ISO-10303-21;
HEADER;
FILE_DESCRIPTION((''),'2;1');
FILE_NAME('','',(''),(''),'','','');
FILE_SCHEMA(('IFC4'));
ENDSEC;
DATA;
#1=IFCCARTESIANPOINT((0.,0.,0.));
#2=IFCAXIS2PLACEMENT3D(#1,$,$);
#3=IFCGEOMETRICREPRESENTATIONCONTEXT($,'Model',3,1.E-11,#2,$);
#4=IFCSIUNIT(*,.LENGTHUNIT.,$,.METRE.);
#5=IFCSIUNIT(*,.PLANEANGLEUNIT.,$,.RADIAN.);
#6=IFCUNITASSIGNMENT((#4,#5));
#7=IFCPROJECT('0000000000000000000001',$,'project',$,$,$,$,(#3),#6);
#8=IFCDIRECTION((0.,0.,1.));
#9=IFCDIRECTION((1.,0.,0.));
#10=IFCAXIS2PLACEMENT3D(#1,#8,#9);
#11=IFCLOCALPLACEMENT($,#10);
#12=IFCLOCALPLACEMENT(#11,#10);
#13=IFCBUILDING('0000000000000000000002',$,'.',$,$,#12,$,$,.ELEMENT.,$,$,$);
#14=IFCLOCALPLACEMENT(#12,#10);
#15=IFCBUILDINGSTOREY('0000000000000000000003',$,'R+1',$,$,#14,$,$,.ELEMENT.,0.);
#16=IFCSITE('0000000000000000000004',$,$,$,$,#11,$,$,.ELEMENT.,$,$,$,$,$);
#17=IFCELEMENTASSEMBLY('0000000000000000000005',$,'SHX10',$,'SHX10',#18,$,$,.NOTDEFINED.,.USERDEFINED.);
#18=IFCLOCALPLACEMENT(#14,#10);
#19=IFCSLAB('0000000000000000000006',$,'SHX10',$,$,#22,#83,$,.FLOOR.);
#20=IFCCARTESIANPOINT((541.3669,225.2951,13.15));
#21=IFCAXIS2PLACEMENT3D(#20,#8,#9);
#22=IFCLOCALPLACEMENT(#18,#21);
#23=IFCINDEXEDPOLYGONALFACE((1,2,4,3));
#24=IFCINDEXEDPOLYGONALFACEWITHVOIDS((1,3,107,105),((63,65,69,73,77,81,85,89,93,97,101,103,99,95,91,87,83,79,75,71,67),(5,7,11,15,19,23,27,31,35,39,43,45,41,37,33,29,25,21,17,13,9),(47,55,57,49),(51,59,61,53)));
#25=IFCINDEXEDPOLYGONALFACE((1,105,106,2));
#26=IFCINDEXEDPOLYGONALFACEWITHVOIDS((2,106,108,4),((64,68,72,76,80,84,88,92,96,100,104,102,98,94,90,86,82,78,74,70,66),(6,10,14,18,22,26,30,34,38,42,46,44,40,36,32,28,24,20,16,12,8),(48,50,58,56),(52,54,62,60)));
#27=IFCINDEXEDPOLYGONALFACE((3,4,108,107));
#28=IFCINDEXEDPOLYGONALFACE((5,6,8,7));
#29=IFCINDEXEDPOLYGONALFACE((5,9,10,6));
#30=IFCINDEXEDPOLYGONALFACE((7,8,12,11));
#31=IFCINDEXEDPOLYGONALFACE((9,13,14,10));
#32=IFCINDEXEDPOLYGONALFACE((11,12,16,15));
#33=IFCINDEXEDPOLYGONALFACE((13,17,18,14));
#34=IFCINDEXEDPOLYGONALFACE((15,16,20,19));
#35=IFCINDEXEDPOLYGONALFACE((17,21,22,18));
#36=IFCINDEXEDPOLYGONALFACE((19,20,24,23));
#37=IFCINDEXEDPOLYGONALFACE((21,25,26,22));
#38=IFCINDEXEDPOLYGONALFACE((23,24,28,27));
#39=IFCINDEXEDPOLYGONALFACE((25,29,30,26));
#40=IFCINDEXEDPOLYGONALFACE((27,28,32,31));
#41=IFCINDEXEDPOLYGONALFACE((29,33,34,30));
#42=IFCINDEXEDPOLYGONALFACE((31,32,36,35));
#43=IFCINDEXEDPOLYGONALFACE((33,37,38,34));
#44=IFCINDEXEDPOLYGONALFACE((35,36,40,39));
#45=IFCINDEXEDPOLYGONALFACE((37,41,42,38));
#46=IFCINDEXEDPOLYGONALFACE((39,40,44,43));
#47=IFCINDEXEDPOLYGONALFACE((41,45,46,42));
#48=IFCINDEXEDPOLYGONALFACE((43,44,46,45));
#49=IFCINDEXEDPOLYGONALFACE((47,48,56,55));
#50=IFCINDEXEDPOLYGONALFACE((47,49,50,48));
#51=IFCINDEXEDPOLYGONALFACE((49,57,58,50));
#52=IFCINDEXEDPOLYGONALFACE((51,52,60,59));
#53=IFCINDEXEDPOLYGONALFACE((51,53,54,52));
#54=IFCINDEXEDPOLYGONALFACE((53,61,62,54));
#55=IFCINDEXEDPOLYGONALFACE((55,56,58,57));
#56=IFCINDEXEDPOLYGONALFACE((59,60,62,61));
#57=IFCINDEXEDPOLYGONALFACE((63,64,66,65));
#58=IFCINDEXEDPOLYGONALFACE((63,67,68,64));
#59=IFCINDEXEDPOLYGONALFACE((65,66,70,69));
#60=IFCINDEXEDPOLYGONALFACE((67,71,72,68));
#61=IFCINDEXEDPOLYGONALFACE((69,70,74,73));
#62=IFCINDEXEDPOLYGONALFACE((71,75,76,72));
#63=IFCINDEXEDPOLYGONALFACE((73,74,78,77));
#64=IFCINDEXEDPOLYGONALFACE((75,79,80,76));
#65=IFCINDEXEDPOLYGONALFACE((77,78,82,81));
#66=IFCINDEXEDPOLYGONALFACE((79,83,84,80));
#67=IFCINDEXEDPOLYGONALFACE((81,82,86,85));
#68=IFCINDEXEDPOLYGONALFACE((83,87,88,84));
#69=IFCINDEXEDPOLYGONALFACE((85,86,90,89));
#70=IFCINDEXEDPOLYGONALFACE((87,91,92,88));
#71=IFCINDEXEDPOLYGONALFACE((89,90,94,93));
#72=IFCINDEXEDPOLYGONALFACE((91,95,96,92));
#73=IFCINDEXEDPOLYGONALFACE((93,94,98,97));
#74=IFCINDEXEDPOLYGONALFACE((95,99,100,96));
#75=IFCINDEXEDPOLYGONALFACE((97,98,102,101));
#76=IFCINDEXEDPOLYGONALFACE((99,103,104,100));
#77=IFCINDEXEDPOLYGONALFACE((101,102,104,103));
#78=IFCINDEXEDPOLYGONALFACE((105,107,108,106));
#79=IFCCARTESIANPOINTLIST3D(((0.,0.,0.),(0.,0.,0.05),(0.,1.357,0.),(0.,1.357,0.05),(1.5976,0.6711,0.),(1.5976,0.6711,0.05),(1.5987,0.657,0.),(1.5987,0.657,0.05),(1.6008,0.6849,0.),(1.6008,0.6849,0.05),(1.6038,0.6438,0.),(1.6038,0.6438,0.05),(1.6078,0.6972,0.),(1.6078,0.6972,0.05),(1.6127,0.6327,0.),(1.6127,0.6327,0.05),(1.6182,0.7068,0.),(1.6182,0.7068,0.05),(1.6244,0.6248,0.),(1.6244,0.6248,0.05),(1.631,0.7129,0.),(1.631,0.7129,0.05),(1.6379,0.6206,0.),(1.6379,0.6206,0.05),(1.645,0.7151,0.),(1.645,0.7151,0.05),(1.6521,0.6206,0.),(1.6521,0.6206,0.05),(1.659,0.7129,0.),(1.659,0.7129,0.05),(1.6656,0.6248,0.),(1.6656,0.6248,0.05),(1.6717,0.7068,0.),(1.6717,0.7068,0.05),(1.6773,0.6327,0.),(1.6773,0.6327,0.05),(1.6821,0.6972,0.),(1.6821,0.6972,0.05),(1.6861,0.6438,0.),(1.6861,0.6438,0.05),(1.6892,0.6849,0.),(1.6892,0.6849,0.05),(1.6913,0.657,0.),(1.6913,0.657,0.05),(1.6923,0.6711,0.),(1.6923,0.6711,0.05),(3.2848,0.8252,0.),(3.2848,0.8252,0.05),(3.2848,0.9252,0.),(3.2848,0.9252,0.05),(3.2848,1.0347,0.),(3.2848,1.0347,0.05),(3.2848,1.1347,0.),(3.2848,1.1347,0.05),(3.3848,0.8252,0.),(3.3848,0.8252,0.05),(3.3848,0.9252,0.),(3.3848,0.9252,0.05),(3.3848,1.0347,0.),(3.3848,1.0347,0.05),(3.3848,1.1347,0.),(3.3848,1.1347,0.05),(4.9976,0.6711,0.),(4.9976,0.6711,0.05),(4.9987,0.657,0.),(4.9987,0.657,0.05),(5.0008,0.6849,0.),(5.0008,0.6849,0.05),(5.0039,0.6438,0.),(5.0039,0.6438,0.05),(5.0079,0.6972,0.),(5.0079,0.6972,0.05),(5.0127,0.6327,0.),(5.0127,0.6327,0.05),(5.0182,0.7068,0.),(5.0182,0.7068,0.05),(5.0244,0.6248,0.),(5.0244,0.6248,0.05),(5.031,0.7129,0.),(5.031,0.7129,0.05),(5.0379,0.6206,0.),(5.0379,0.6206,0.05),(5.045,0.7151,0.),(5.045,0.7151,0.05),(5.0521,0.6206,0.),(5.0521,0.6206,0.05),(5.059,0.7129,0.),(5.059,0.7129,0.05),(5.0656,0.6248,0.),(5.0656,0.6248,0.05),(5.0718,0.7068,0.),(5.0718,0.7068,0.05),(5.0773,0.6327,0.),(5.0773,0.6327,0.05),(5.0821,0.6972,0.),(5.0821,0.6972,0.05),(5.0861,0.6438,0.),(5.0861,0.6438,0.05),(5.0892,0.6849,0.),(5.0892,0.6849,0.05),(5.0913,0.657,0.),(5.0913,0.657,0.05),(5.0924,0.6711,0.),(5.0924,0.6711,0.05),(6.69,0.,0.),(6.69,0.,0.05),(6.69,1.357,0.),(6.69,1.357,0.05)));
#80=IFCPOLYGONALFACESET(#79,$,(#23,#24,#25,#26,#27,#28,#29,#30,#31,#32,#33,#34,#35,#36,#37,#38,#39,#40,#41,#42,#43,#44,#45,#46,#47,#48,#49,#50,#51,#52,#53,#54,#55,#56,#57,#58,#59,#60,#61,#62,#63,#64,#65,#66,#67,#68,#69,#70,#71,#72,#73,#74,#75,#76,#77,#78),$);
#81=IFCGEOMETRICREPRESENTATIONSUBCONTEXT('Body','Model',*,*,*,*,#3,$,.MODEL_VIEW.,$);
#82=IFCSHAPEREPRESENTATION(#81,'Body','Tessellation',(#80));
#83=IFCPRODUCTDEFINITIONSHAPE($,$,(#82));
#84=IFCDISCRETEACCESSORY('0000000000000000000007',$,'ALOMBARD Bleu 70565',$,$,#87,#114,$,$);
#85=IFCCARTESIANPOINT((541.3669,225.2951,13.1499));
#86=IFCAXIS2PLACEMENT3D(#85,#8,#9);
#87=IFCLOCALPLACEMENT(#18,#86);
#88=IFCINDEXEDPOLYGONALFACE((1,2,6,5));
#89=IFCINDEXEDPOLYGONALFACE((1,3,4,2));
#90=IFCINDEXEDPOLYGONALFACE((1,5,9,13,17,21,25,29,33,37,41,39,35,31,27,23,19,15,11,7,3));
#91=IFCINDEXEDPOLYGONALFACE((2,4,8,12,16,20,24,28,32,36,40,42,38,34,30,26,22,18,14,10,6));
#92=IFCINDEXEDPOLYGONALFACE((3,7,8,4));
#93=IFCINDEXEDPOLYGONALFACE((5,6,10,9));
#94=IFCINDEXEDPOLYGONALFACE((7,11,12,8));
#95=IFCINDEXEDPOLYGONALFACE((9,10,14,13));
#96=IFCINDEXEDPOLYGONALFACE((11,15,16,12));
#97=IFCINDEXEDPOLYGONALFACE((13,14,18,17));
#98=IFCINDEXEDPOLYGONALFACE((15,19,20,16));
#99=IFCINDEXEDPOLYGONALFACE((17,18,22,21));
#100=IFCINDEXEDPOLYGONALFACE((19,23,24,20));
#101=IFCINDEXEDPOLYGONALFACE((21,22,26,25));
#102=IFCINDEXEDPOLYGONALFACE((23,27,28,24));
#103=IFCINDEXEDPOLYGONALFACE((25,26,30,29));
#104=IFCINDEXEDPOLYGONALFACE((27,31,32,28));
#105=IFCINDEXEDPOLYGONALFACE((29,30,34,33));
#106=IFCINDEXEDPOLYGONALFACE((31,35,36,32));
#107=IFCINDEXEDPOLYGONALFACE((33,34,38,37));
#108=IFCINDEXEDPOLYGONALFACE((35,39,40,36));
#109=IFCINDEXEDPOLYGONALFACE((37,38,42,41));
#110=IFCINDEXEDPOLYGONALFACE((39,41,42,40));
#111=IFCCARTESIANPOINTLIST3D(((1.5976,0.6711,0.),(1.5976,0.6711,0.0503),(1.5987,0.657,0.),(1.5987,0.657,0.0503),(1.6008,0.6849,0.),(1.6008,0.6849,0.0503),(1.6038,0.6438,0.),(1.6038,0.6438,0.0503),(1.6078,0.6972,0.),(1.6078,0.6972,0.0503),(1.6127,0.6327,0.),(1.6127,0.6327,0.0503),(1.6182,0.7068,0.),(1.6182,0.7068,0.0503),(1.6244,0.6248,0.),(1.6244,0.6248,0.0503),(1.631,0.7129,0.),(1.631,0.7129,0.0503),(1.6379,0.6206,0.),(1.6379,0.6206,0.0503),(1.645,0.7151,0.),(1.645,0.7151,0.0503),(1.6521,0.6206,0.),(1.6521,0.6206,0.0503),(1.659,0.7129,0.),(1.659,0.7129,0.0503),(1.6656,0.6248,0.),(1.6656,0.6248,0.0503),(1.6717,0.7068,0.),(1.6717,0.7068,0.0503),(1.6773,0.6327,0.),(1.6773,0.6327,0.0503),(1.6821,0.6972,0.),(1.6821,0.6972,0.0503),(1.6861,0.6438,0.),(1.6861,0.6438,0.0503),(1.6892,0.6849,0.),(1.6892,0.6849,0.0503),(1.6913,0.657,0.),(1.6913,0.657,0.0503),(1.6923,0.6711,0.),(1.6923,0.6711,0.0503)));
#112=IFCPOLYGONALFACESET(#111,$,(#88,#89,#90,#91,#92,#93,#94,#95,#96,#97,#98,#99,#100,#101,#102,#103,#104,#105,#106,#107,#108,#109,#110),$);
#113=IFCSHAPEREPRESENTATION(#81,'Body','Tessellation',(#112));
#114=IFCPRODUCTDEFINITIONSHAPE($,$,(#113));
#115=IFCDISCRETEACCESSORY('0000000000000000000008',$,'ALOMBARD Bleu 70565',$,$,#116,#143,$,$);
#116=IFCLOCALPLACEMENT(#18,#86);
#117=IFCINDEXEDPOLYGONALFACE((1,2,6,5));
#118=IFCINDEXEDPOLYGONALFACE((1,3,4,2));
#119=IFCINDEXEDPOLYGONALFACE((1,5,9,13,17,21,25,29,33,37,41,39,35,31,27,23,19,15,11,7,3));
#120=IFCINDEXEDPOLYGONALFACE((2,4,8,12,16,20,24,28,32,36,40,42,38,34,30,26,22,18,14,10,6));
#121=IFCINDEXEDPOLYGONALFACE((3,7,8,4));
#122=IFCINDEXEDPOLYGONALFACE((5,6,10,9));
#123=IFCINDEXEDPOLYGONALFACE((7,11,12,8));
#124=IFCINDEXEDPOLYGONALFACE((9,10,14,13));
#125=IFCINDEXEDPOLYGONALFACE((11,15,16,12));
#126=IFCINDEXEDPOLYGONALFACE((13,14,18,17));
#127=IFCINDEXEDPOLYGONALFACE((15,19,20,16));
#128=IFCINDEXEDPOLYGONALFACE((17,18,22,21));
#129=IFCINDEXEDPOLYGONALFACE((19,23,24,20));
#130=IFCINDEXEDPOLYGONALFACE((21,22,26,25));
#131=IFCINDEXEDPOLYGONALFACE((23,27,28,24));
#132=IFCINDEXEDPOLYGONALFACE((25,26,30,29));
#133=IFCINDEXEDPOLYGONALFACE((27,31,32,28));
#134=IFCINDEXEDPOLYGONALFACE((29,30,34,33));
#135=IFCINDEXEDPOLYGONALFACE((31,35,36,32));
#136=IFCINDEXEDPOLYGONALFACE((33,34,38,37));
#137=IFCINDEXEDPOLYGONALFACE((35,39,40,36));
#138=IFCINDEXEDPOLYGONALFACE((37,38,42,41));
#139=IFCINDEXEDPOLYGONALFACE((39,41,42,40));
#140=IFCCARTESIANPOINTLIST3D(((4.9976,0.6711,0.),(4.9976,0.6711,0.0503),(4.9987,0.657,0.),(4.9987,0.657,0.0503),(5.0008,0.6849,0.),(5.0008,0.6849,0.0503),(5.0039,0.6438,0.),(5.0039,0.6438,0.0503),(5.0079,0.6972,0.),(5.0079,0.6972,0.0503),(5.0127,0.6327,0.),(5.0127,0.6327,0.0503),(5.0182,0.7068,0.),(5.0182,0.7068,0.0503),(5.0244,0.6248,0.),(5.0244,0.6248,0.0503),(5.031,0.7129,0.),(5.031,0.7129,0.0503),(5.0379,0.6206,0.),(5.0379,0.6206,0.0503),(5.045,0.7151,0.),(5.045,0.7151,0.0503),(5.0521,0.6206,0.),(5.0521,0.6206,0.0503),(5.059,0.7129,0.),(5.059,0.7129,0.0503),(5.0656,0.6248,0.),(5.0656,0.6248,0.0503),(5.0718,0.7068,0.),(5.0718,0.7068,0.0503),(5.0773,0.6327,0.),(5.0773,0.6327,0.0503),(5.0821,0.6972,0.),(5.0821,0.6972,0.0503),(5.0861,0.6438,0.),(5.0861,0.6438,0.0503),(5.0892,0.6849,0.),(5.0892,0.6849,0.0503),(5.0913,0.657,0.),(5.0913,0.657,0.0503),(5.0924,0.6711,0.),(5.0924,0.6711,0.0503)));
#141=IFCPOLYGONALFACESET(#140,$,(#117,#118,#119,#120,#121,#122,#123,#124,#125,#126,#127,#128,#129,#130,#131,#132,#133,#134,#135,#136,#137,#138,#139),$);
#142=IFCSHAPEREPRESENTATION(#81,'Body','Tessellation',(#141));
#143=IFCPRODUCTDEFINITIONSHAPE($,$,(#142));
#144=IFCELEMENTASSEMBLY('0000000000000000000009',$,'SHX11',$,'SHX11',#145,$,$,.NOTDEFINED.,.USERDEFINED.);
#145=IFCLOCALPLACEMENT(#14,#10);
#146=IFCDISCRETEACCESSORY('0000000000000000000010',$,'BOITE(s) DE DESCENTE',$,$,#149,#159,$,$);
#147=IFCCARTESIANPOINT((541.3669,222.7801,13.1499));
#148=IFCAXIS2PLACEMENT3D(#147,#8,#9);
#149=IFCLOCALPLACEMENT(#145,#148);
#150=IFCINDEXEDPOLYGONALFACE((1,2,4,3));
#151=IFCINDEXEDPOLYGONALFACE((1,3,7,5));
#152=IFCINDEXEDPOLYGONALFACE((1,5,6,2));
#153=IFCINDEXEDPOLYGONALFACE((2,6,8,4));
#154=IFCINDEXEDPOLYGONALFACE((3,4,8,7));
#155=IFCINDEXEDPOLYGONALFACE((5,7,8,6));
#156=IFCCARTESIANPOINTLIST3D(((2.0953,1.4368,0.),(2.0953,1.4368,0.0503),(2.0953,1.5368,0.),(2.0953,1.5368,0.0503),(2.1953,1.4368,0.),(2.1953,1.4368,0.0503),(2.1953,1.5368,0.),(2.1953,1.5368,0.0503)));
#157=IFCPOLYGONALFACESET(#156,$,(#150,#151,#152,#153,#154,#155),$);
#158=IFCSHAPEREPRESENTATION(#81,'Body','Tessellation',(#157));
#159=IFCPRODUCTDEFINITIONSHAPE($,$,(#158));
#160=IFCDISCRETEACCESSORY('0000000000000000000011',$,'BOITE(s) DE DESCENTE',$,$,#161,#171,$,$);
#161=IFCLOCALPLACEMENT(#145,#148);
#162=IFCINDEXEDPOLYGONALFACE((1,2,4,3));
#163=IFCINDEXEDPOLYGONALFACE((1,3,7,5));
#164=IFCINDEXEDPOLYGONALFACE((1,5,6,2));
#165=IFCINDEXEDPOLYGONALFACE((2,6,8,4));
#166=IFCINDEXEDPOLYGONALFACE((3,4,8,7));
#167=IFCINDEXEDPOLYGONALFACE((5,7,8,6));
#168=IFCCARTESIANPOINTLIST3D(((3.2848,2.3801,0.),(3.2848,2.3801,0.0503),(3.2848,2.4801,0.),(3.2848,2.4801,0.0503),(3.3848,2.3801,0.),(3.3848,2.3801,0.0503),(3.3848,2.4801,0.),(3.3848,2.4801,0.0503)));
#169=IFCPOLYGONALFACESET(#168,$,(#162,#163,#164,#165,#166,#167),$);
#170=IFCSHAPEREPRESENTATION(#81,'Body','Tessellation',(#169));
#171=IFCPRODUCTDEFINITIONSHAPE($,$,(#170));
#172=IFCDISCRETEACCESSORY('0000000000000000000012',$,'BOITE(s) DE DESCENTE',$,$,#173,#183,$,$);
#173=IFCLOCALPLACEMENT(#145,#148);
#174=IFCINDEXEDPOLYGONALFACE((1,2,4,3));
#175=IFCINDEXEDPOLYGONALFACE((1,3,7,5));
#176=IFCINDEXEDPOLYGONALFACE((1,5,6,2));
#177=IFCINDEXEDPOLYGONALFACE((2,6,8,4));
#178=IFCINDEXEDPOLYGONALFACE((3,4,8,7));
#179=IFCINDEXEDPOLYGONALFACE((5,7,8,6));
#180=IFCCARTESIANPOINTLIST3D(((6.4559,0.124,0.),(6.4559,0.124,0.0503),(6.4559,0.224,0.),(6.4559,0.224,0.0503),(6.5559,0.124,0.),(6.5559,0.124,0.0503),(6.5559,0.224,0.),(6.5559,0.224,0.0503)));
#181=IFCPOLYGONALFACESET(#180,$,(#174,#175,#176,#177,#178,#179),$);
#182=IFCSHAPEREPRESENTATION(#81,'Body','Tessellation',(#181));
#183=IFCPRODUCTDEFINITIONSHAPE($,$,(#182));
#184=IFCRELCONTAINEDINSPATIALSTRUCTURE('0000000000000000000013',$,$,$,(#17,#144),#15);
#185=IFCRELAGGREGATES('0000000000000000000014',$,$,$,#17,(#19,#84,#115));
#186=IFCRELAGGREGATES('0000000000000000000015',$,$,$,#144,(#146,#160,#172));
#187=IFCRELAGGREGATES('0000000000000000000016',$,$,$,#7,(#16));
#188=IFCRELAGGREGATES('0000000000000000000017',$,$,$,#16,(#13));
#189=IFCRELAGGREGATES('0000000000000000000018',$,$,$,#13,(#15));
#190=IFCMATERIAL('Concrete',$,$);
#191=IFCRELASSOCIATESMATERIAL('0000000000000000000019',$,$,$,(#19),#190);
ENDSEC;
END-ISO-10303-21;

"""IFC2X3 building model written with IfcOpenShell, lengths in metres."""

from ifc_helpers import new_model, si_unit, frame, frame_2d, origin, origin_with_axes, origin_2d_with_axis, place, context, subcontext, project, spatial, polyline, circle, outline, extrude, material, element, aggregate, save


model = new_model("IFC2X3")

# Units and contexts
model_context = context("Model", 3, precision=1e-11, world=origin())
body_context = subcontext(model_context, "Body", "Model", "MODEL_VIEW")
ifc_project = project(units=[si_unit("LENGTHUNIT", "METRE"), si_unit("PLANEANGLEUNIT", "RADIAN")], contexts=[model_context])

# Site, building, storey
site_placement = place(None, origin_with_axes())
site = spatial("IfcSite", under=ifc_project, at=site_placement, CompositionType="ELEMENT")
building_placement = place(site_placement, origin_with_axes())
building = spatial("IfcBuilding", under=site, at=building_placement, Name=".", CompositionType="ELEMENT")
storey_placement = place(building_placement, origin_with_axes())
storey = spatial("IfcBuildingStorey", under=building, at=storey_placement, Name="R+1", CompositionType="ELEMENT", Elevation=0.0)

# Element assembly, slab, openings, discrete accessories
assembly_1_placement = place(storey_placement, origin_with_axes())
assembly_1 = element("IfcElementAssembly", 1, at=assembly_1_placement, inside=storey, Name="SHX10", ObjectType="SHX10", AssemblyPlace="NOTDEFINED", PredefinedType="USERDEFINED")
ifc_material = material(Name="Concrete")
slab_placement = place(assembly_1_placement, frame((541.3669, 225.2951, 13.15), z_axis=(0.0, 0.0, 1.0), x_axis=(1.0, 0.0, 0.0)))
slab = element("IfcSlab", 2, at=slab_placement, material=ifc_material, Name="SHX10", PredefinedType="FLOOR", context=body_context, shape_type="SweptSolid", body=[
    extrude(outline(polyline([(0.0, 0.0), (0.0, -6.69), (1.3571, -6.69), (1.3571, 0.0), (0.0, 0.0)])), frame((0.0, 0.0, 0.0), z_axis=(0.0, 0.0, 1.0), x_axis=(0.0, 1.0, 0.0)), (0.0, 0.0, 1.0), 0.05),
])
opening_1_placement = place(slab_placement, frame((1.645, 0.6676, 0.0), z_axis=(0.0, 0.0, 1.0), x_axis=(1.0, 0.0, 0.0)))
element("IfcOpeningElement", 3, at=opening_1_placement, cuts=slab, ObjectType="Opening", context=body_context, shape_type="SweptSolid", body=[
    extrude(circle(Radius=0.0475, at=origin_2d_with_axis()), frame((0.0, 0.0, 0.0), z_axis=(0.0, 0.0, 1.0), x_axis=(0.0, 1.0, 0.0)), (0.0, 0.0, 1.0), 0.05),
])
opening_2_placement = place(slab_placement, frame((5.045, 0.6676, 0.0), z_axis=(0.0, 0.0, 1.0), x_axis=(1.0, 0.0, 0.0)))
element("IfcOpeningElement", 4, at=opening_2_placement, cuts=slab, ObjectType="Opening", context=body_context, shape_type="SweptSolid", body=[
    extrude(circle(Radius=0.0475, at=origin_2d_with_axis()), frame((0.0, 0.0, 0.0), z_axis=(0.0, 0.0, 1.0), x_axis=(0.0, 1.0, 0.0)), (0.0, 0.0, 1.0), 0.05),
])
opening_3_placement = place(slab_placement, origin_with_axes())
element("IfcOpeningElement", 5, at=opening_3_placement, cuts=slab, ObjectType="Opening", context=body_context, shape_type="SweptSolid", body=[
    extrude(outline(polyline([(0.8252, -3.2848), (0.8252, -3.3848), (0.9252, -3.3848), (0.9252, -3.2848), (0.8252, -3.2848)])), frame((0.0, 0.0, 0.0), z_axis=(0.0, 0.0, 1.0), x_axis=(0.0, 1.0, 0.0)), (0.0, 0.0, 1.0), 0.05),
])
opening_4_placement = place(slab_placement, origin_with_axes())
element("IfcOpeningElement", 6, at=opening_4_placement, cuts=slab, ObjectType="Opening", context=body_context, shape_type="SweptSolid", body=[
    extrude(outline(polyline([(1.0347, -3.2848), (1.0347, -3.3848), (1.1347, -3.3848), (1.1347, -3.2848), (1.0347, -3.2848)])), frame((0.0, 0.0, 0.0), z_axis=(0.0, 0.0, 1.0), x_axis=(0.0, 1.0, 0.0)), (0.0, 0.0, 1.0), 0.05),
])
discrete_accessory_1_placement = place(assembly_1_placement, frame((541.3669, 225.2951, 13.1499), z_axis=(0.0, 0.0, 1.0), x_axis=(1.0, 0.0, 0.0)))
discrete_accessory_1 = element("IfcDiscreteAccessory", 7, at=discrete_accessory_1_placement, Name="ALOMBARD Bleu 70565", context=body_context, shape_type="SweptSolid", body=[
    extrude(circle(Radius=0.0475, at=frame_2d((0.6676, -1.645), x_axis=(1.0, 0.0))), frame((0.0, 0.0, 0.0), z_axis=(0.0, 0.0, 1.0), x_axis=(0.0, 1.0, 0.0)), (0.0, 0.0, 1.0), 0.0503),
])
discrete_accessory_2_placement = place(assembly_1_placement, frame((541.3669, 225.2951, 13.1499), z_axis=(0.0, 0.0, 1.0), x_axis=(1.0, 0.0, 0.0)))
discrete_accessory_2 = element("IfcDiscreteAccessory", 8, at=discrete_accessory_2_placement, Name="ALOMBARD Bleu 70565", context=body_context, shape_type="SweptSolid", body=[
    extrude(circle(Radius=0.0475, at=frame_2d((0.6676, -5.045), x_axis=(1.0, 0.0))), frame((0.0, 0.0, 0.0), z_axis=(0.0, 0.0, 1.0), x_axis=(0.0, 1.0, 0.0)), (0.0, 0.0, 1.0), 0.0503),
])
aggregate(assembly_1, [slab, discrete_accessory_1, discrete_accessory_2])

# Element assembly, discrete accessories
assembly_2_placement = place(storey_placement, origin_with_axes())
assembly_2 = element("IfcElementAssembly", 9, at=assembly_2_placement, inside=storey, Name="SHX11", ObjectType="SHX11", AssemblyPlace="NOTDEFINED", PredefinedType="USERDEFINED")
discrete_accessory_3_placement = place(assembly_2_placement, frame((541.3669, 222.7801, 13.1499), z_axis=(0.0, 0.0, 1.0), x_axis=(1.0, 0.0, 0.0)))
discrete_accessory_3 = element("IfcDiscreteAccessory", 10, at=discrete_accessory_3_placement, Name="BOITE(s) DE DESCENTE", context=body_context, shape_type="SweptSolid", body=[
    extrude(outline(polyline([(1.4368, -2.0953), (1.4368, -2.1953), (1.5368, -2.1953), (1.5368, -2.0953), (1.4368, -2.0953)])), frame((0.0, 0.0, 0.0), z_axis=(0.0, 0.0, 1.0), x_axis=(0.0, 1.0, 0.0)), (0.0, 0.0, 1.0), 0.0503),
])
discrete_accessory_4_placement = place(assembly_2_placement, frame((541.3669, 222.7801, 13.1499), z_axis=(0.0, 0.0, 1.0), x_axis=(1.0, 0.0, 0.0)))
discrete_accessory_4 = element("IfcDiscreteAccessory", 11, at=discrete_accessory_4_placement, Name="BOITE(s) DE DESCENTE", context=body_context, shape_type="SweptSolid", body=[
    extrude(outline(polyline([(2.3801, -3.2848), (2.3801, -3.3848), (2.4801, -3.3848), (2.4801, -3.2848), (2.3801, -3.2848)])), frame((0.0, 0.0, 0.0), z_axis=(0.0, 0.0, 1.0), x_axis=(0.0, 1.0, 0.0)), (0.0, 0.0, 1.0), 0.0503),
])
discrete_accessory_5_placement = place(assembly_2_placement, frame((541.3669, 222.7801, 13.1499), z_axis=(0.0, 0.0, 1.0), x_axis=(1.0, 0.0, 0.0)))
discrete_accessory_5 = element("IfcDiscreteAccessory", 12, at=discrete_accessory_5_placement, Name="BOITE(s) DE DESCENTE", context=body_context, shape_type="SweptSolid", body=[
    extrude(outline(polyline([(0.124, -6.4559), (0.124, -6.5559), (0.224, -6.5559), (0.224, -6.4559), (0.124, -6.4559)])), frame((0.0, 0.0, 0.0), z_axis=(0.0, 0.0, 1.0), x_axis=(0.0, 1.0, 0.0)), (0.0, 0.0, 1.0), 0.0503),
])
aggregate(assembly_2, [discrete_accessory_3, discrete_accessory_4, discrete_accessory_5])

save(model, "model.ifc")
